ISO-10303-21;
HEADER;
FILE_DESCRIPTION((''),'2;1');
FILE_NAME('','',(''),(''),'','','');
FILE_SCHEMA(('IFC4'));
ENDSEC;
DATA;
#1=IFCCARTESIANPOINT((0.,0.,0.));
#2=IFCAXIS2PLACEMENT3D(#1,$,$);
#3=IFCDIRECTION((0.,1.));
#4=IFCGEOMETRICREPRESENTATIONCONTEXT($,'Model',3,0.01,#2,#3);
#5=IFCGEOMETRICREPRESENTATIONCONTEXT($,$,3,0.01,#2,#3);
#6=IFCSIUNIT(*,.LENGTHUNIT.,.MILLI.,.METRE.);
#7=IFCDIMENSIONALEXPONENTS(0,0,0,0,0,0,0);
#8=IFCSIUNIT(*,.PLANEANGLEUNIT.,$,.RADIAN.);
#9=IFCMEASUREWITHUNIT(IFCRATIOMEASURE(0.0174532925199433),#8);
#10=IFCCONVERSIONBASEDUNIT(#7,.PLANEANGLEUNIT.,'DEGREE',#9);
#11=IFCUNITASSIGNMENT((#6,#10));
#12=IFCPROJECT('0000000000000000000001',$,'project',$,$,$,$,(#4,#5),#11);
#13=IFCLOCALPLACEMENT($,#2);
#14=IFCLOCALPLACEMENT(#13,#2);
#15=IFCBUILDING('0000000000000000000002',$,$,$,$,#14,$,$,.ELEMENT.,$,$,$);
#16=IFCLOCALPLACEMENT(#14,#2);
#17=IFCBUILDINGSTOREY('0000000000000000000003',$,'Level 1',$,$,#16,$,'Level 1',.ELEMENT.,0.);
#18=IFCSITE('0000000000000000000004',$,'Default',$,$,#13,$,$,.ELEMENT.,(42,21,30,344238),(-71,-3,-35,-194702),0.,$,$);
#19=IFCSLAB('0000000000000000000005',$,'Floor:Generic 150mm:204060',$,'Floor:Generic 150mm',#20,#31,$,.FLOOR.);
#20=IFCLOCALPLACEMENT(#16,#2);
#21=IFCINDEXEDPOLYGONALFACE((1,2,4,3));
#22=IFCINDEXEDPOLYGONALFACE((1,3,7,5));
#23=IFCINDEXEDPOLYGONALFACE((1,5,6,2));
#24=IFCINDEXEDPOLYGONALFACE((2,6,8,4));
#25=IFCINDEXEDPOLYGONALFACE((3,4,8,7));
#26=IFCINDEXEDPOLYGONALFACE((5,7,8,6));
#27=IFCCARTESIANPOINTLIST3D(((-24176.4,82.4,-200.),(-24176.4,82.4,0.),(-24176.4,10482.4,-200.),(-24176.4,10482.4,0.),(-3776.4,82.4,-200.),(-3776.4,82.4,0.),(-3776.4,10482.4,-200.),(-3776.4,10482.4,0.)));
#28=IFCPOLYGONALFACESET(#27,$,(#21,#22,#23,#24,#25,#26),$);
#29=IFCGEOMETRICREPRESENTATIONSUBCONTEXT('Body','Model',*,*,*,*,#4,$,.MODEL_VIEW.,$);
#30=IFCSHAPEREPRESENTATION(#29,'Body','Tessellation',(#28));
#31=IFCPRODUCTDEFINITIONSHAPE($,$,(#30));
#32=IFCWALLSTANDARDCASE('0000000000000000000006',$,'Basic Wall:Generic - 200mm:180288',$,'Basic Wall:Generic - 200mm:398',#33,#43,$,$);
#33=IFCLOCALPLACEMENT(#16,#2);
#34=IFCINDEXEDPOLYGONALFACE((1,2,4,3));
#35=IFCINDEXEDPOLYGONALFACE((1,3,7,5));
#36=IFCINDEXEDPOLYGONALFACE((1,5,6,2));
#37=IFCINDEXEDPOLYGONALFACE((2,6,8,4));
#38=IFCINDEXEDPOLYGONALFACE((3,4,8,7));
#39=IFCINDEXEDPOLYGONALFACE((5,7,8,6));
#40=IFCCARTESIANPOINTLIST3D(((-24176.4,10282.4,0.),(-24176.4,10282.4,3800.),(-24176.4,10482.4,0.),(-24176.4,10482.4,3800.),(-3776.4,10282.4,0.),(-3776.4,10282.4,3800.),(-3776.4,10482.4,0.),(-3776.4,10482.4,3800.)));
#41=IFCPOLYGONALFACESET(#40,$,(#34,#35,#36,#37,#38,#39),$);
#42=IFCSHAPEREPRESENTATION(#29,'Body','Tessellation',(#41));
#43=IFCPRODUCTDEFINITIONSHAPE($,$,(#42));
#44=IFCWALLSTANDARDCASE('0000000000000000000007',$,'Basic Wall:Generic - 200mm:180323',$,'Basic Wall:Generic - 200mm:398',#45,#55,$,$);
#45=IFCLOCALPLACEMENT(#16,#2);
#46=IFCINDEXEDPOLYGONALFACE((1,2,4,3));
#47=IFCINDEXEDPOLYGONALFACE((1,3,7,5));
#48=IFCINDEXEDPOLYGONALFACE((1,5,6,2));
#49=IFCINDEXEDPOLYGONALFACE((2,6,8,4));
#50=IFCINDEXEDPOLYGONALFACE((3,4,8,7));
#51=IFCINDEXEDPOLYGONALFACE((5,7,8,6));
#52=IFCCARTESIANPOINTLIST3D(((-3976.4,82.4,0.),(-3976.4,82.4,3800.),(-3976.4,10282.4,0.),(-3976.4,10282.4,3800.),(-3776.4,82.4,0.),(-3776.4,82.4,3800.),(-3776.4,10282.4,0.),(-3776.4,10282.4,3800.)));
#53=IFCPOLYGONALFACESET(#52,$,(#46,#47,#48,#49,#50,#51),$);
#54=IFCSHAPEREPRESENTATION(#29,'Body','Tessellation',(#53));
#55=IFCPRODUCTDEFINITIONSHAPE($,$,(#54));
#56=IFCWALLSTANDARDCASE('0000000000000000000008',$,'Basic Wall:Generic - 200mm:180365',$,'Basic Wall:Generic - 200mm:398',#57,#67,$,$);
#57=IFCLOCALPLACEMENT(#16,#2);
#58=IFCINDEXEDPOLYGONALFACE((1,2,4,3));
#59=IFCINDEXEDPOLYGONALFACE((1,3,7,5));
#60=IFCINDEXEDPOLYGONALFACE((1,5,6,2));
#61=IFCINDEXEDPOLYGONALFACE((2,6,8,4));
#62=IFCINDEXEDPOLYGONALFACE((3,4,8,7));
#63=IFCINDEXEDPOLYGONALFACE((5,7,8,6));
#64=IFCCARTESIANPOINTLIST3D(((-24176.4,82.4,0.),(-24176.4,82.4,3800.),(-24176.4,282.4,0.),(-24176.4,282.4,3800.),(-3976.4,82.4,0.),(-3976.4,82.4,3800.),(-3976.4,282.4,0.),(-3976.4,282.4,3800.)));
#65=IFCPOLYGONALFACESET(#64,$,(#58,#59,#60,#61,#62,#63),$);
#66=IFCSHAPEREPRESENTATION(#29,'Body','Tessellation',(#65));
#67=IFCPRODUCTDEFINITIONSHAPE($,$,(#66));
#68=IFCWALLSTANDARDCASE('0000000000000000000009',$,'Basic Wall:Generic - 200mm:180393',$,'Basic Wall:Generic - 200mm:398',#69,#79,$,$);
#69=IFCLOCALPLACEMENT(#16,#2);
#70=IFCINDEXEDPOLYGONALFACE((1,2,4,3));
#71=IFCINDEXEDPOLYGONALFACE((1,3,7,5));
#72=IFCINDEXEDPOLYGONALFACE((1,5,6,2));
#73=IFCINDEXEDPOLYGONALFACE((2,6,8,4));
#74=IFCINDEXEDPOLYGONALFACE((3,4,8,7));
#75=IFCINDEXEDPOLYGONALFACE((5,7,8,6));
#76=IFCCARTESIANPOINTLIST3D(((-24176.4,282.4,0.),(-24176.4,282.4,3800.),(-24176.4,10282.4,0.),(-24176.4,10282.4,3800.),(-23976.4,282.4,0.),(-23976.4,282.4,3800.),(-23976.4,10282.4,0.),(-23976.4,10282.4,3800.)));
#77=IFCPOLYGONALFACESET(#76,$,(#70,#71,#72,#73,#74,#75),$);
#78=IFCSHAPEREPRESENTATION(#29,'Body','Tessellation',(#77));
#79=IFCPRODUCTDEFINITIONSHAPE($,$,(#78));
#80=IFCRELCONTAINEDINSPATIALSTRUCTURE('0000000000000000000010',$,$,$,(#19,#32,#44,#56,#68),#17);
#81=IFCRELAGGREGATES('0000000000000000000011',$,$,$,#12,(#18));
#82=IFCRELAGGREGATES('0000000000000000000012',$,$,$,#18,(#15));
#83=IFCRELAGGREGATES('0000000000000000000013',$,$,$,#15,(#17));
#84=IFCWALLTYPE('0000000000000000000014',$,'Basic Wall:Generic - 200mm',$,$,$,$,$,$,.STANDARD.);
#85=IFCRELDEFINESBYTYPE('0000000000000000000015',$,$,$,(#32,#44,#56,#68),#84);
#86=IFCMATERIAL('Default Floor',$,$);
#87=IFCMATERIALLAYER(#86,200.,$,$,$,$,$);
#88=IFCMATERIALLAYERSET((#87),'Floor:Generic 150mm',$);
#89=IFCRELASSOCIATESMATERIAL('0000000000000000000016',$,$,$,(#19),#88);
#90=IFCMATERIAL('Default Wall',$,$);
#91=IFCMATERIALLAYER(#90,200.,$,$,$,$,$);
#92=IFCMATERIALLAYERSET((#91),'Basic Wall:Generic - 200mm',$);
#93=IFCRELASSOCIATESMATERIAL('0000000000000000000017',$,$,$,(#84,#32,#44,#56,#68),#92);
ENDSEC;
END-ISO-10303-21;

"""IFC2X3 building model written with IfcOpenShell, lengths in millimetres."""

from ifc_helpers import new_model, entity, si_unit, converted_unit, direction, frame, frame_2d, origin, place, context, subcontext, project, spatial, rectangle, extrude, material, layer, layer_set, layer_usage, type_object, element, save


model = new_model("IFC2X3")

# Units and contexts
model_context = context("Model", 3, precision=0.01, world=origin(), true_north=direction((0.0, 1.0)))
context_of_model = context(None, 3, precision=0.01, world=origin(), true_north=direction((0.0, 1.0)))
body_context = subcontext(model_context, "Body", "Model", "MODEL_VIEW")
ifc_project = project(units=[si_unit("LENGTHUNIT", "METRE", prefix="MILLI"), converted_unit("PLANEANGLEUNIT", "DEGREE", entity("IfcRatioMeasure", 0.0174532925199433), si_unit("PLANEANGLEUNIT", "RADIAN"), dimensions=[0, 0, 0, 0, 0, 0, 0])], contexts=[model_context, context_of_model])

# Site, building, storey
site_placement = place(None, origin())
site = spatial("IfcSite", under=ifc_project, at=site_placement, Name="Default", CompositionType="ELEMENT", RefLatitude=(42, 21, 30, 344238), RefLongitude=(-71, -3, -35, -194702), RefElevation=0.0)
building_placement = place(site_placement, origin())
building = spatial("IfcBuilding", under=site, at=building_placement, CompositionType="ELEMENT")
storey_placement = place(building_placement, origin())
storey = spatial("IfcBuildingStorey", under=building, at=storey_placement, Name="Level 1", LongName="Level 1", CompositionType="ELEMENT", Elevation=0.0)

# Slab
ifc_material_1 = material(Name="Default Floor")
ifc_layer_1 = layer(ifc_material_1, 200.0)
ifc_layer_set_1 = layer_set([ifc_layer_1], Name="Floor:Generic 150mm")
ifc_layer_usage_1 = layer_usage(ifc_layer_set_1, "AXIS3", "POSITIVE", 0.0)
slab_placement = place(storey_placement, origin())
element("IfcSlab", 1, at=slab_placement, inside=storey, material=ifc_layer_usage_1, Name="Floor:Generic 150mm:204060", ObjectType="Floor:Generic 150mm", PredefinedType="FLOOR", context=body_context, shape_type="SweptSolid", body=[
    extrude(rectangle(XDim=10400.0, YDim=20400.0, at=frame_2d((0.0, 0.0), x_axis=(1.0, 0.0))), frame((-13976.4, 5282.4, 0.0), z_axis=(0.0, 0.0, -1.0), x_axis=(0.0, 1.0, 0.0)), (0.0, 0.0, 1.0), 200.0),
])

# Walls
ifc_material_2 = material(Name="Default Wall")
ifc_layer_2 = layer(ifc_material_2, 200.0)
ifc_layer_set_2 = layer_set([ifc_layer_2], Name="Basic Wall:Generic - 200mm")
ifc_layer_usage_2 = layer_usage(ifc_layer_set_2, "AXIS2", "NEGATIVE", 100.0)
wall_type = type_object("IfcWallType", Name="Basic Wall:Generic - 200mm", PredefinedType="STANDARD", material=ifc_layer_set_2)
wall_1_placement = place(storey_placement, frame((-24176.4, 10382.4, 0.0)))
element("IfcWallStandardCase", 2, at=wall_1_placement, inside=storey, type_object=wall_type, material=ifc_layer_usage_2, Name="Basic Wall:Generic - 200mm:180288", ObjectType="Basic Wall:Generic - 200mm:398", context=body_context, shape_type="SweptSolid", body=[
    extrude(rectangle(XDim=20400.0, YDim=200.0, at=frame_2d((10200.0, 0.0), x_axis=(-1.0, 0.0))), origin(), (0.0, 0.0, 1.0), 3800.0),
])
ifc_layer_usage_3 = layer_usage(ifc_layer_set_2, "AXIS2", "NEGATIVE", 100.0)
wall_2_placement = place(storey_placement, frame((-3876.4, 10282.4, 0.0), z_axis=(0.0, 0.0, 1.0), x_axis=(0.0, -1.0, 0.0)))
element("IfcWallStandardCase", 3, at=wall_2_placement, inside=storey, type_object=wall_type, material=ifc_layer_usage_3, Name="Basic Wall:Generic - 200mm:180323", ObjectType="Basic Wall:Generic - 200mm:398", context=body_context, shape_type="SweptSolid", body=[
    extrude(rectangle(XDim=10200.0, YDim=200.0, at=frame_2d((5100.0, 0.0), x_axis=(-1.0, 0.0))), origin(), (0.0, 0.0, 1.0), 3800.0),
])
ifc_layer_usage_4 = layer_usage(ifc_layer_set_2, "AXIS2", "NEGATIVE", 100.0)
wall_3_placement = place(storey_placement, frame((-3976.4, 182.4, 0.0), z_axis=(0.0, 0.0, 1.0), x_axis=(-1.0, 0.0, 0.0)))
element("IfcWallStandardCase", 4, at=wall_3_placement, inside=storey, type_object=wall_type, material=ifc_layer_usage_4, Name="Basic Wall:Generic - 200mm:180365", ObjectType="Basic Wall:Generic - 200mm:398", context=body_context, shape_type="SweptSolid", body=[
    extrude(rectangle(XDim=20200.0, YDim=200.0, at=frame_2d((10100.0, 0.0), x_axis=(-1.0, 0.0))), origin(), (0.0, 0.0, 1.0), 3800.0),
])
ifc_layer_usage_5 = layer_usage(ifc_layer_set_2, "AXIS2", "NEGATIVE", 100.0)
wall_4_placement = place(storey_placement, frame((-24076.4, 282.4, 0.0), z_axis=(0.0, 0.0, 1.0), x_axis=(0.0, 1.0, 0.0)))
element("IfcWallStandardCase", 5, at=wall_4_placement, inside=storey, type_object=wall_type, material=ifc_layer_usage_5, Name="Basic Wall:Generic - 200mm:180393", ObjectType="Basic Wall:Generic - 200mm:398", context=body_context, shape_type="SweptSolid", body=[
    extrude(rectangle(XDim=10000.0, YDim=200.0, at=frame_2d((5000.0, 0.0), x_axis=(-1.0, 0.0))), origin(), (0.0, 0.0, 1.0), 3800.0),
])

save(model, "model.ifc")
